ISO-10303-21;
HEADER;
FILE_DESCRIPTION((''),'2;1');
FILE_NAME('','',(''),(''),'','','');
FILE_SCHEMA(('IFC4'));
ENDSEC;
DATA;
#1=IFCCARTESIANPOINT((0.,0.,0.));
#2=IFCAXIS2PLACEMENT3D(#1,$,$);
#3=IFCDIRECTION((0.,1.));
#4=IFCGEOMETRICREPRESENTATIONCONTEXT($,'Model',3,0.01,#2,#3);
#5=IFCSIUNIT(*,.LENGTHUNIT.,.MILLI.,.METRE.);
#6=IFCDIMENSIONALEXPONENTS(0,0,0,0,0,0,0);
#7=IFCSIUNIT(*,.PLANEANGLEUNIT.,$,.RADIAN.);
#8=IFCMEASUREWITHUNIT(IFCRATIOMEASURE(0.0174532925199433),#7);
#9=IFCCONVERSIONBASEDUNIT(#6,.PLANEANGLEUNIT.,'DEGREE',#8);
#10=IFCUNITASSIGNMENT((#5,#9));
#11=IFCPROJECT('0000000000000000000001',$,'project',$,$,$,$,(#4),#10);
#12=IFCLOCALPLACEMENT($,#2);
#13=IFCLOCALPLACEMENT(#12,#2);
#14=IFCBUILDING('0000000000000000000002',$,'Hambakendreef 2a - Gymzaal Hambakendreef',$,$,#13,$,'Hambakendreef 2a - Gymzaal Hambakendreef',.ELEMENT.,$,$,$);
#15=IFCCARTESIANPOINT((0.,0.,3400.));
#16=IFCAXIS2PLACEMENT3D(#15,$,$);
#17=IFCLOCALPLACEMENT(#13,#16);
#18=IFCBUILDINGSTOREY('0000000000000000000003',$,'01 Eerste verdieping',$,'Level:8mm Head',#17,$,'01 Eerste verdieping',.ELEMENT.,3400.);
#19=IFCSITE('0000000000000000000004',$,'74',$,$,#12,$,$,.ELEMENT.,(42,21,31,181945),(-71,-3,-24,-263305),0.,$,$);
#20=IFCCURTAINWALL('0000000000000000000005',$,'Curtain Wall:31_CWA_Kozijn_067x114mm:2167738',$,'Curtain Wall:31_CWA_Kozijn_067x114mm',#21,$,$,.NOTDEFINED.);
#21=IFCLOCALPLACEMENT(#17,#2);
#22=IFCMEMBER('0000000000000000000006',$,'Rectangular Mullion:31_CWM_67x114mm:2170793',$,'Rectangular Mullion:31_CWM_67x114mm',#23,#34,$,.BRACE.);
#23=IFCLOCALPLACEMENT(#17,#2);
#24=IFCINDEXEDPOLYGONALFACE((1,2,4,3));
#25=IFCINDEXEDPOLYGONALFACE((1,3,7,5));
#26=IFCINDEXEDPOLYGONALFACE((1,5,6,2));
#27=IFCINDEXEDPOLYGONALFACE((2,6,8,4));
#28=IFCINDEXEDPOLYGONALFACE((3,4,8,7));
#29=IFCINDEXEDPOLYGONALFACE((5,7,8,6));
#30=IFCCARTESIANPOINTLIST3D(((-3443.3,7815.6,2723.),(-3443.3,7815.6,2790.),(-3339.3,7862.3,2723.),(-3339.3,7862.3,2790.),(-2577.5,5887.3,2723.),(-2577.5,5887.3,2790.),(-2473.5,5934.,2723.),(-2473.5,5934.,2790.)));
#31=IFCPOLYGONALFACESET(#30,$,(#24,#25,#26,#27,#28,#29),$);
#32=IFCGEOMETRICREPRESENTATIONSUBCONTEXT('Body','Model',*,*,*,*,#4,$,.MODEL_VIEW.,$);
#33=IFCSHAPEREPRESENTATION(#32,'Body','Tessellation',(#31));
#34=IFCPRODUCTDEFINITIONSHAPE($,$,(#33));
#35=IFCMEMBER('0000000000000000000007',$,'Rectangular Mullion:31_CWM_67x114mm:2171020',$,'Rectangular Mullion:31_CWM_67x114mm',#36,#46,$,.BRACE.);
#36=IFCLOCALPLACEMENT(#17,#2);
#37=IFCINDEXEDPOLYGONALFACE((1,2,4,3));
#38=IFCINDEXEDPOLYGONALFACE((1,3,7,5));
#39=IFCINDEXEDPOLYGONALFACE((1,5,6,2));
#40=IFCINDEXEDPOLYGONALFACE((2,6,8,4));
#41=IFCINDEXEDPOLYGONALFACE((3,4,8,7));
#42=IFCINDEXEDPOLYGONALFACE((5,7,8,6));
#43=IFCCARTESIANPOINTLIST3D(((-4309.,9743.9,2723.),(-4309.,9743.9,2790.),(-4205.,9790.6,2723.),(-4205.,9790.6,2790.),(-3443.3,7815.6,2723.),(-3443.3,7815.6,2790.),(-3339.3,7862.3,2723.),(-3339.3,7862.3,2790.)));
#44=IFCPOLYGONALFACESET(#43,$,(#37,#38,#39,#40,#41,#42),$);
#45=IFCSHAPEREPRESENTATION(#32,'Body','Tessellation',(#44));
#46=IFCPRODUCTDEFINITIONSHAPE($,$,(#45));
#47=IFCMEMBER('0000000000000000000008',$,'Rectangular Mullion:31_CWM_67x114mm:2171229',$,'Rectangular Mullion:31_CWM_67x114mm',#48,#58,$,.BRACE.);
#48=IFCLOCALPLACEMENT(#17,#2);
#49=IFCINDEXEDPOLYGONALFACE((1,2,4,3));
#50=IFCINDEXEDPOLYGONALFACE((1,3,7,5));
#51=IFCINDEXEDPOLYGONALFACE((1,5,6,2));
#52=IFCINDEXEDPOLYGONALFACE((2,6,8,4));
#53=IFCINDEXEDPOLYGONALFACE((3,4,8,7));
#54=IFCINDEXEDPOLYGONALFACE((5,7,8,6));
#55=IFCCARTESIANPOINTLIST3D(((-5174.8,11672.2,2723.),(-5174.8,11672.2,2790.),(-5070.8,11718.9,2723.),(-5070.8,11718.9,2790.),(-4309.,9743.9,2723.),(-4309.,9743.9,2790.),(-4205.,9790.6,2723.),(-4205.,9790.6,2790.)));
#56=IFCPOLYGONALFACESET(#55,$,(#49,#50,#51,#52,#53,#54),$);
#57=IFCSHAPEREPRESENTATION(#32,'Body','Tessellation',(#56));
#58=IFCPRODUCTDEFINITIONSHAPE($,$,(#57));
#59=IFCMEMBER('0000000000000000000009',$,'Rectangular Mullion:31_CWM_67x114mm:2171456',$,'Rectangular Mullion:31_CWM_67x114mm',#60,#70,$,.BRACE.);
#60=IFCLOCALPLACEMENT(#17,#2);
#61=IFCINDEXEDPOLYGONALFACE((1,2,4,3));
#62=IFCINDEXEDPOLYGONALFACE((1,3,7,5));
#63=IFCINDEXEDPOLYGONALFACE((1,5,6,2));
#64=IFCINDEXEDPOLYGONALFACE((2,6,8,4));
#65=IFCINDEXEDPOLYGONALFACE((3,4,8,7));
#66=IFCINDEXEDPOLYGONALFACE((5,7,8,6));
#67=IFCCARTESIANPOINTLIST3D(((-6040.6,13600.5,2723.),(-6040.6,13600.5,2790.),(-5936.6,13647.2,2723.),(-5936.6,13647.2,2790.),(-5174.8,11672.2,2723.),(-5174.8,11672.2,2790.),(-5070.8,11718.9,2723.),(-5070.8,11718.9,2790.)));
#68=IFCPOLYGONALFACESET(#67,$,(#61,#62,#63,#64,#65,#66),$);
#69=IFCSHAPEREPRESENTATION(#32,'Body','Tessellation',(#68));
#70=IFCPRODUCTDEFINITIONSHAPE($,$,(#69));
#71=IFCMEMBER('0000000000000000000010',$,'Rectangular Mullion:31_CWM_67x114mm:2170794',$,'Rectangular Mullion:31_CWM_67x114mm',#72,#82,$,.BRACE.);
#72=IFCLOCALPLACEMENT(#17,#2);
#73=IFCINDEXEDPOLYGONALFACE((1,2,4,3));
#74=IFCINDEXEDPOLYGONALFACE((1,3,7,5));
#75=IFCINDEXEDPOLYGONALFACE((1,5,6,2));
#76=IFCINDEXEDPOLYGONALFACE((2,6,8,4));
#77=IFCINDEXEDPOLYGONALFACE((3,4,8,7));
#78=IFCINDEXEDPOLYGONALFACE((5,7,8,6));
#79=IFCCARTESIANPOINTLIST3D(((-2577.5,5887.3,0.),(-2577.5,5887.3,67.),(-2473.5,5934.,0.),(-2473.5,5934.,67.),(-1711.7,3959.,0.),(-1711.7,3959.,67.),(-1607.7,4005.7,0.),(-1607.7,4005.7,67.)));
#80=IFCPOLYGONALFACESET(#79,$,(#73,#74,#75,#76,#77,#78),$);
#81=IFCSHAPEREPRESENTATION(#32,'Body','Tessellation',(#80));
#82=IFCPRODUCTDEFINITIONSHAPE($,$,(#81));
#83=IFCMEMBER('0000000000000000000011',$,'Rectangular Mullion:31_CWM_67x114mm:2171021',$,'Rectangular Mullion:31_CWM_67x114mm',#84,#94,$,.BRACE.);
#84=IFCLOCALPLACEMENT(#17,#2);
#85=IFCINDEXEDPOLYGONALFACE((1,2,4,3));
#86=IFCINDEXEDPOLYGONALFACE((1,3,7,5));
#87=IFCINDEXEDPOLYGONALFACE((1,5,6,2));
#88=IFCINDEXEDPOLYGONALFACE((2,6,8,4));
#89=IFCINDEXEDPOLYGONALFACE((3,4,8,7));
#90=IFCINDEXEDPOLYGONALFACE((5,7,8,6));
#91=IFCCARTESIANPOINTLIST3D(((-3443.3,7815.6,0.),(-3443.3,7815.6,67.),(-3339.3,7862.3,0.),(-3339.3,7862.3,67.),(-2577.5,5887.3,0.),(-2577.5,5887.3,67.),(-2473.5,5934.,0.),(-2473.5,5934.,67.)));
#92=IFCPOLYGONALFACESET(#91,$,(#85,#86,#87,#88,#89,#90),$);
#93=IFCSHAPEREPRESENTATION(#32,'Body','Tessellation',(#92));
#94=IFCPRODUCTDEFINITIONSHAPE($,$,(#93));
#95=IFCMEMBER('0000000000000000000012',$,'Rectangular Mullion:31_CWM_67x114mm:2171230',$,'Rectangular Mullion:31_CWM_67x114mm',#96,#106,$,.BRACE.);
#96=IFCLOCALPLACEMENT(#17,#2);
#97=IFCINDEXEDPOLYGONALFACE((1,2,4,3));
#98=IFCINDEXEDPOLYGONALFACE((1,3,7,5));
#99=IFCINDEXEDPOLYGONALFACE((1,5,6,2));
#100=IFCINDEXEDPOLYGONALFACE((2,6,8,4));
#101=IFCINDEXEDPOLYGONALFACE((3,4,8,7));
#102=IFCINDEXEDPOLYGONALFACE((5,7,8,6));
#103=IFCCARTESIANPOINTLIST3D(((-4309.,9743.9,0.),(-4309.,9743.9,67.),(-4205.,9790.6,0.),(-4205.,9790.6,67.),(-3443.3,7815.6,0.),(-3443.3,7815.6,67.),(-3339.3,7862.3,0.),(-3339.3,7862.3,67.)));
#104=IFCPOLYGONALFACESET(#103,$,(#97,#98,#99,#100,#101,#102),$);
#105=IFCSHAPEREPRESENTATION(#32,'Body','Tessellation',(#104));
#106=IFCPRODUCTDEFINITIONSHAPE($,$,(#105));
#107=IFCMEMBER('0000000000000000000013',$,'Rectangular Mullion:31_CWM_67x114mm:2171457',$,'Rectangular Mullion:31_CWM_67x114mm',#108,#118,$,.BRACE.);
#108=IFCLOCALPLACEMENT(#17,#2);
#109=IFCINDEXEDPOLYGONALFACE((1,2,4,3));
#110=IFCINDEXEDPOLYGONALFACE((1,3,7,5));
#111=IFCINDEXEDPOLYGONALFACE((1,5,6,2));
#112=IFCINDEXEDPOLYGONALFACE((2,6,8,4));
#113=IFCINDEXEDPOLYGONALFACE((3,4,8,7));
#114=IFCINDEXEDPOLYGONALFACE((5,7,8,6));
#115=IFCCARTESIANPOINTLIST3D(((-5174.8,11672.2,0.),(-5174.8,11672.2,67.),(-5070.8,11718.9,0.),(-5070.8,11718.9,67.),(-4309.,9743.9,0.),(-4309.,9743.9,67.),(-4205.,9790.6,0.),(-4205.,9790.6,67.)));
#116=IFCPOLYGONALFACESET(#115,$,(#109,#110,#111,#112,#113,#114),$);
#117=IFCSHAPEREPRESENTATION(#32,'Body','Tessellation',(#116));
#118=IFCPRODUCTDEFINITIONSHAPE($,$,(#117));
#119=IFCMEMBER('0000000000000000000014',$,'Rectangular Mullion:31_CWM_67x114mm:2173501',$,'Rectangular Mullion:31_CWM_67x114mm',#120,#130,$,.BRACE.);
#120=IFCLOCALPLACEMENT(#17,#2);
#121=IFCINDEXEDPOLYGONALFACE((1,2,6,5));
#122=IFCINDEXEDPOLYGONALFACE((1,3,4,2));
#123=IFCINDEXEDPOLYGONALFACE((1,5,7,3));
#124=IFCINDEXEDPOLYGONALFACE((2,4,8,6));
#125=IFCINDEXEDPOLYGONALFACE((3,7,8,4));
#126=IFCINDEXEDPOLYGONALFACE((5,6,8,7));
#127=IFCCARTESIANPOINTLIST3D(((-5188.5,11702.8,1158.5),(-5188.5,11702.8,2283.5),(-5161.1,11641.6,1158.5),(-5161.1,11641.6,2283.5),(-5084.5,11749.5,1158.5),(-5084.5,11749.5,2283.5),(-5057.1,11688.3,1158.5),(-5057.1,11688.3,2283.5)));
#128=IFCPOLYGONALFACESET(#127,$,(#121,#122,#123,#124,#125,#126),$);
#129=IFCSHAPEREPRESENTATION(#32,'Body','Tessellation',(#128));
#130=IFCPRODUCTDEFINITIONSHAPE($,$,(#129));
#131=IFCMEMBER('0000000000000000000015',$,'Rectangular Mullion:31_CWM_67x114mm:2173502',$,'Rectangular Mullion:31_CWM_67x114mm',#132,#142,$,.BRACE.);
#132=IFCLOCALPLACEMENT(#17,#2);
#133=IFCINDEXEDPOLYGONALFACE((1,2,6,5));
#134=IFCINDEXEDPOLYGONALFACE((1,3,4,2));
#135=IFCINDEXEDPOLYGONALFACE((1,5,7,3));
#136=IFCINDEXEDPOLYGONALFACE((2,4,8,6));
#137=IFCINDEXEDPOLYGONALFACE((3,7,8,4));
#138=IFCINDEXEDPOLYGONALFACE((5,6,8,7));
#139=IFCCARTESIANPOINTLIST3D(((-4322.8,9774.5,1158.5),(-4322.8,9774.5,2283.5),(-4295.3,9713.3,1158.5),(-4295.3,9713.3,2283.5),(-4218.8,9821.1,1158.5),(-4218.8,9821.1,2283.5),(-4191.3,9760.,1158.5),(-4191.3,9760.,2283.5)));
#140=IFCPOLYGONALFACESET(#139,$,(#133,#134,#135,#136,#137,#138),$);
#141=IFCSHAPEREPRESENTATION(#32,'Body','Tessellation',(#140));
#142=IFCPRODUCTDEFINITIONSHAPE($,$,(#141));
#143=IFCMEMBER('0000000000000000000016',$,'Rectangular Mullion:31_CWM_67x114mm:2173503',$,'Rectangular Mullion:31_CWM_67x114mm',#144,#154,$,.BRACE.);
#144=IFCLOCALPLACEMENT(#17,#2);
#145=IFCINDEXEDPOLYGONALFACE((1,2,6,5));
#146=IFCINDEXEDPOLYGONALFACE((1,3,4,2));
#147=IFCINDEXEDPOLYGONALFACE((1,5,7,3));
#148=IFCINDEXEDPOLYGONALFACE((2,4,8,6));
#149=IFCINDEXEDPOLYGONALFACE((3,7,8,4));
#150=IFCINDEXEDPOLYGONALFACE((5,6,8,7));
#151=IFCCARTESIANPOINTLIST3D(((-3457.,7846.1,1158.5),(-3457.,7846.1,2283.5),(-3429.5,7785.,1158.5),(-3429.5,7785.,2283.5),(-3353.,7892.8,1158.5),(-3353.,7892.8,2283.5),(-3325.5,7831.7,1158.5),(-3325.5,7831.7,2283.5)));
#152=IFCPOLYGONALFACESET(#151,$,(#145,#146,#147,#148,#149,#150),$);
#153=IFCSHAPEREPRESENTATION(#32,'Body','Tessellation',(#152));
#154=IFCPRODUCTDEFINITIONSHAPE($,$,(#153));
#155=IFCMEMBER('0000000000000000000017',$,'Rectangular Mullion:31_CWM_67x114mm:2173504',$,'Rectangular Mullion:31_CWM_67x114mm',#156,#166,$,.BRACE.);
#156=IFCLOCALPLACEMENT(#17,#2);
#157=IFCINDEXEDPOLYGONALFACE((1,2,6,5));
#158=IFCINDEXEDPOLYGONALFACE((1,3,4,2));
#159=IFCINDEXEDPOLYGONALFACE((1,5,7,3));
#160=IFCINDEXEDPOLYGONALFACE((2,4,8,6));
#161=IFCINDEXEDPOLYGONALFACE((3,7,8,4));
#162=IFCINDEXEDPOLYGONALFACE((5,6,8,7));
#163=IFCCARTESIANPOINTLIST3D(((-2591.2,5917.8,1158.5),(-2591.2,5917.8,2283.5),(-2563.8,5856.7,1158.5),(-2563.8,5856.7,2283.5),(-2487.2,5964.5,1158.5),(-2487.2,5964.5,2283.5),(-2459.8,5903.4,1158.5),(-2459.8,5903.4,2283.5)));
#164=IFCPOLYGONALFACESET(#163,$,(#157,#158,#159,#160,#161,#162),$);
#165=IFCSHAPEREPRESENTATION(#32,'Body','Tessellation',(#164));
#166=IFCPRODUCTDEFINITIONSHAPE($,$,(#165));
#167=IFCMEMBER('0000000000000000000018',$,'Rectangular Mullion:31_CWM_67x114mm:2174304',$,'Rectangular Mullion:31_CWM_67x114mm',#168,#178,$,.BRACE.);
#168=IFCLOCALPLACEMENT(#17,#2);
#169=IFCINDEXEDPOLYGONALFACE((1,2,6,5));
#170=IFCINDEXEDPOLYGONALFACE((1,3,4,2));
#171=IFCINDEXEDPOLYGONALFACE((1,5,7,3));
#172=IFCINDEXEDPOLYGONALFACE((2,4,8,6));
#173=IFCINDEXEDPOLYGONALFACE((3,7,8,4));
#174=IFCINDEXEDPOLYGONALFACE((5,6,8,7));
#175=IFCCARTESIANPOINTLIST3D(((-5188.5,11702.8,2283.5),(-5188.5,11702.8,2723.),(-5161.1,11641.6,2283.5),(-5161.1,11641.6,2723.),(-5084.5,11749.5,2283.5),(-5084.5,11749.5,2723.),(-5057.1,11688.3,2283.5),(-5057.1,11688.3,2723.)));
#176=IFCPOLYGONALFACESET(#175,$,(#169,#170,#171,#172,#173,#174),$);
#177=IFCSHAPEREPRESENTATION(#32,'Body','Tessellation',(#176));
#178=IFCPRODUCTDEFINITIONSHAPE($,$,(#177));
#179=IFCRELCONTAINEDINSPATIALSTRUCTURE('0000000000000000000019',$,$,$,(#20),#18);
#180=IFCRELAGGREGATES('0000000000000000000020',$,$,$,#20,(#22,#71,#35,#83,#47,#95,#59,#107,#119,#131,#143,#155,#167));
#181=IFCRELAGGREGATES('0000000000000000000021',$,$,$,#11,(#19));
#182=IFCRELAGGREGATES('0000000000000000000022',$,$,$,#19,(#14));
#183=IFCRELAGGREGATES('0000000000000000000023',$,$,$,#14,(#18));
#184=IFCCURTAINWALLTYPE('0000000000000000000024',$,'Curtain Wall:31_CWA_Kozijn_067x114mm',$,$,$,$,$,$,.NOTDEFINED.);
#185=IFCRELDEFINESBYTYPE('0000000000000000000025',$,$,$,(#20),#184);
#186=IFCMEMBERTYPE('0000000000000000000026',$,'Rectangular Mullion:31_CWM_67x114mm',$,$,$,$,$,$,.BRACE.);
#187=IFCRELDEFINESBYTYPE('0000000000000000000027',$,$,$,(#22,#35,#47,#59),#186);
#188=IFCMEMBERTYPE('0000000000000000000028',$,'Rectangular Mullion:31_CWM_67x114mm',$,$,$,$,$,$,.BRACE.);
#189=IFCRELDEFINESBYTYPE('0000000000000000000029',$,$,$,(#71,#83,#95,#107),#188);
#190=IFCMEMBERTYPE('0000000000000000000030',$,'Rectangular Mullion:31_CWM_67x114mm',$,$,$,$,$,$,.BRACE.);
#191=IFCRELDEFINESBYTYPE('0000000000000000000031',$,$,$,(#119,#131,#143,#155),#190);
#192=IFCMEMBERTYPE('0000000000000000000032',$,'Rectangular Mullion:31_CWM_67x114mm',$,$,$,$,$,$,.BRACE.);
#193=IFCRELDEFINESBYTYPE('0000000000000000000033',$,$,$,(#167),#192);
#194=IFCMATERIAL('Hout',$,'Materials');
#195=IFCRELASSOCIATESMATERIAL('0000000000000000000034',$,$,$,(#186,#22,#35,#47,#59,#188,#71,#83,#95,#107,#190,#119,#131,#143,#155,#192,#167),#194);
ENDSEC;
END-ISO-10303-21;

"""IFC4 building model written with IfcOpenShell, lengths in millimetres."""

from ifc_helpers import new_model, entity, si_unit, converted_unit, direction, frame, origin, place, context, subcontext, project, spatial, indexed_curve, outline, extrude, source, transform, mapped, material, type_object, type_shapes, element, aggregate, save


model = new_model("IFC4")

# Units and contexts
model_context = context("Model", 3, precision=0.01, world=origin(), true_north=direction((0.0, 1.0)))
body_context = subcontext(model_context, "Body", "Model", "MODEL_VIEW")
ifc_project = project(units=[si_unit("LENGTHUNIT", "METRE", prefix="MILLI"), converted_unit("PLANEANGLEUNIT", "DEGREE", entity("IfcRatioMeasure", 0.0174532925199433), si_unit("PLANEANGLEUNIT", "RADIAN"), dimensions=[0, 0, 0, 0, 0, 0, 0])], contexts=[model_context])

# Site, building, storey
site_placement = place(None, origin())
site = spatial("IfcSite", under=ifc_project, at=site_placement, Name="74", CompositionType="ELEMENT", RefLatitude=(42, 21, 31, 181945), RefLongitude=(-71, -3, -24, -263305), RefElevation=0.0)
building_placement = place(site_placement, origin())
building = spatial("IfcBuilding", under=site, at=building_placement, Name="Hambakendreef 2a - Gymzaal Hambakendreef", LongName="Hambakendreef 2a - Gymzaal Hambakendreef", CompositionType="ELEMENT")
storey_placement = place(building_placement, frame((0.0, 0.0, 3400.0)))
storey = spatial("IfcBuildingStorey", under=building, at=storey_placement, Name="01 Eerste verdieping", ObjectType="Level:8mm Head", LongName="01 Eerste verdieping", CompositionType="ELEMENT", Elevation=3400.0)

# Curtain wall, members
curtain_wall_type = type_object("IfcCurtainWallType", Name="Curtain Wall:31_CWA_Kozijn_067x114mm", PredefinedType="NOTDEFINED")
curtain_wall_placement = place(storey_placement, frame((0.0, 0.0, -3400.0)))
curtain_wall = element("IfcCurtainWall", 1, at=curtain_wall_placement, inside=storey, type_object=curtain_wall_type, Name="Curtain Wall:31_CWA_Kozijn_067x114mm:2167738", ObjectType="Curtain Wall:31_CWA_Kozijn_067x114mm", PredefinedType="NOTDEFINED")
ifc_material_1 = material(Name="Hout", Category="Materials")
member_type_1 = type_object("IfcMemberType", Name="Rectangular Mullion:31_CWM_67x114mm", PredefinedType="BRACE", material=ifc_material_1)
shared_shape_1 = source(origin(), body_context, "Body", "SweptSolid", [
    extrude(outline(indexed_curve([(-57.0, -33.5), (57.0, -33.5), (57.0, 33.5), (-57.0, 33.5), (-57.0, -33.5)], self_intersect=False)), frame((-33.5, 0.0, -2113.8), z_axis=(0.0, 0.0, 1.0), x_axis=(0.0, -1.0, 0.0)), (0.0, 0.0, 1.0), 2113.8),
])
type_shapes(member_type_1, [shared_shape_1])
member_1_placement = place(storey_placement, frame((-2525.5, 5910.6, 2790.0), z_axis=(0.40959, -0.91227, 0.0), x_axis=(0.0, 0.0, 1.0)))
member_1 = element("IfcMember", 2, at=member_1_placement, type_object=member_type_1, material=ifc_material_1, Name="Rectangular Mullion:31_CWM_67x114mm:2170793", ObjectType="Rectangular Mullion:31_CWM_67x114mm", PredefinedType="BRACE", context=body_context, shape_type="MappedRepresentation", body=[
    mapped(shared_shape_1, transform((0.0, 0.0, 0.0), scale=1.0)),
])
member_2_placement = place(storey_placement, frame((-3391.3, 7838.9, 2790.0), z_axis=(0.40959, -0.91227, 0.0), x_axis=(0.0, 0.0, 1.0)))
member_2 = element("IfcMember", 3, at=member_2_placement, type_object=member_type_1, material=ifc_material_1, Name="Rectangular Mullion:31_CWM_67x114mm:2171020", ObjectType="Rectangular Mullion:31_CWM_67x114mm", PredefinedType="BRACE", context=body_context, shape_type="MappedRepresentation", body=[
    mapped(shared_shape_1, transform((0.0, 0.0, 0.0), scale=1.0)),
])
member_3_placement = place(storey_placement, frame((-4257.0, 9767.2, 2790.0), z_axis=(0.40959, -0.91227, 0.0), x_axis=(0.0, 0.0, 1.0)))
member_3 = element("IfcMember", 4, at=member_3_placement, type_object=member_type_1, material=ifc_material_1, Name="Rectangular Mullion:31_CWM_67x114mm:2171229", ObjectType="Rectangular Mullion:31_CWM_67x114mm", PredefinedType="BRACE", context=body_context, shape_type="MappedRepresentation", body=[
    mapped(shared_shape_1, transform((0.0, 0.0, 0.0), scale=1.0)),
])
member_4_placement = place(storey_placement, frame((-5122.8, 11695.6, 2790.0), z_axis=(0.40959, -0.91227, 0.0), x_axis=(0.0, 0.0, 1.0)))
member_4 = element("IfcMember", 5, at=member_4_placement, type_object=member_type_1, material=ifc_material_1, Name="Rectangular Mullion:31_CWM_67x114mm:2171456", ObjectType="Rectangular Mullion:31_CWM_67x114mm", PredefinedType="BRACE", context=body_context, shape_type="MappedRepresentation", body=[
    mapped(shared_shape_1, transform((0.0, 0.0, 0.0), scale=1.0)),
])
member_type_2 = type_object("IfcMemberType", Name="Rectangular Mullion:31_CWM_67x114mm", PredefinedType="BRACE", material=ifc_material_1)
shared_shape_2 = source(origin(), body_context, "Body", "SweptSolid", [
    extrude(outline(indexed_curve([(-57.0, -33.5), (57.0, -33.5), (57.0, 33.5), (-57.0, 33.5), (-57.0, -33.5)], self_intersect=False)), frame((-33.5, 0.0, -2113.8), z_axis=(0.0, 0.0, 1.0), x_axis=(0.0, -1.0, 0.0)), (0.0, 0.0, 1.0), 2113.8),
])
type_shapes(member_type_2, [shared_shape_2])
member_5_placement = place(storey_placement, frame((-2525.5, 5910.6, 0.0), z_axis=(-0.40959, 0.91227, 0.0), x_axis=(0.0, 0.0, -1.0)))
member_5 = element("IfcMember", 6, at=member_5_placement, type_object=member_type_2, material=ifc_material_1, Name="Rectangular Mullion:31_CWM_67x114mm:2170794", ObjectType="Rectangular Mullion:31_CWM_67x114mm", PredefinedType="BRACE", context=body_context, shape_type="MappedRepresentation", body=[
    mapped(shared_shape_2, transform((0.0, 0.0, 0.0), scale=1.0)),
])
member_6_placement = place(storey_placement, frame((-3391.3, 7838.9, 0.0), z_axis=(-0.40959, 0.91227, 0.0), x_axis=(0.0, 0.0, -1.0)))
member_6 = element("IfcMember", 7, at=member_6_placement, type_object=member_type_2, material=ifc_material_1, Name="Rectangular Mullion:31_CWM_67x114mm:2171021", ObjectType="Rectangular Mullion:31_CWM_67x114mm", PredefinedType="BRACE", context=body_context, shape_type="MappedRepresentation", body=[
    mapped(shared_shape_2, transform((0.0, 0.0, 0.0), scale=1.0)),
])
member_7_placement = place(storey_placement, frame((-4257.0, 9767.2, 0.0), z_axis=(-0.40959, 0.91227, 0.0), x_axis=(0.0, 0.0, -1.0)))
member_7 = element("IfcMember", 8, at=member_7_placement, type_object=member_type_2, material=ifc_material_1, Name="Rectangular Mullion:31_CWM_67x114mm:2171230", ObjectType="Rectangular Mullion:31_CWM_67x114mm", PredefinedType="BRACE", context=body_context, shape_type="MappedRepresentation", body=[
    mapped(shared_shape_2, transform((0.0, 0.0, 0.0), scale=1.0)),
])
member_8_placement = place(storey_placement, frame((-5122.8, 11695.6, 0.0), z_axis=(-0.40959, 0.91227, 0.0), x_axis=(0.0, 0.0, -1.0)))
member_8 = element("IfcMember", 9, at=member_8_placement, type_object=member_type_2, material=ifc_material_1, Name="Rectangular Mullion:31_CWM_67x114mm:2171457", ObjectType="Rectangular Mullion:31_CWM_67x114mm", PredefinedType="BRACE", context=body_context, shape_type="MappedRepresentation", body=[
    mapped(shared_shape_2, transform((0.0, 0.0, 0.0), scale=1.0)),
])
member_type_3 = type_object("IfcMemberType", Name="Rectangular Mullion:31_CWM_67x114mm", PredefinedType="BRACE", material=ifc_material_1)
shared_shape_3 = source(origin(), body_context, "Body", "SweptSolid", [
    extrude(outline(indexed_curve([(-57.0, -33.5), (57.0, -33.5), (57.0, 33.5), (-57.0, 33.5), (-57.0, -33.5)], self_intersect=False)), frame((0.0, 0.0, -1125.0), z_axis=(0.0, 0.0, 1.0), x_axis=(0.0, -1.0, 0.0)), (0.0, 0.0, 1.0), 1125.0),
])
type_shapes(member_type_3, [shared_shape_3])
member_9_placement = place(storey_placement, frame((-5122.8, 11695.6, 1158.5), z_axis=(0.0, 0.0, -1.0), x_axis=(0.40959, -0.91227, 0.0)))
member_9 = element("IfcMember", 10, at=member_9_placement, type_object=member_type_3, material=ifc_material_1, Name="Rectangular Mullion:31_CWM_67x114mm:2173501", ObjectType="Rectangular Mullion:31_CWM_67x114mm", PredefinedType="BRACE", context=body_context, shape_type="MappedRepresentation", body=[
    mapped(shared_shape_3, transform((0.0, 0.0, 0.0), scale=1.0)),
])
member_10_placement = place(storey_placement, frame((-4257.0, 9767.2, 1158.5), z_axis=(0.0, 0.0, -1.0), x_axis=(0.40959, -0.91227, 0.0)))
member_10 = element("IfcMember", 11, at=member_10_placement, type_object=member_type_3, material=ifc_material_1, Name="Rectangular Mullion:31_CWM_67x114mm:2173502", ObjectType="Rectangular Mullion:31_CWM_67x114mm", PredefinedType="BRACE", context=body_context, shape_type="MappedRepresentation", body=[
    mapped(shared_shape_3, transform((0.0, 0.0, 0.0), scale=1.0)),
])
member_11_placement = place(storey_placement, frame((-3391.3, 7838.9, 1158.5), z_axis=(0.0, 0.0, -1.0), x_axis=(0.40959, -0.91227, 0.0)))
member_11 = element("IfcMember", 12, at=member_11_placement, type_object=member_type_3, material=ifc_material_1, Name="Rectangular Mullion:31_CWM_67x114mm:2173503", ObjectType="Rectangular Mullion:31_CWM_67x114mm", PredefinedType="BRACE", context=body_context, shape_type="MappedRepresentation", body=[
    mapped(shared_shape_3, transform((0.0, 0.0, 0.0), scale=1.0)),
])
member_12_placement = place(storey_placement, frame((-2525.5, 5910.6, 1158.5), z_axis=(0.0, 0.0, -1.0), x_axis=(0.40959, -0.91227, 0.0)))
member_12 = element("IfcMember", 13, at=member_12_placement, type_object=member_type_3, material=ifc_material_1, Name="Rectangular Mullion:31_CWM_67x114mm:2173504", ObjectType="Rectangular Mullion:31_CWM_67x114mm", PredefinedType="BRACE", context=body_context, shape_type="MappedRepresentation", body=[
    mapped(shared_shape_3, transform((0.0, 0.0, 0.0), scale=1.0)),
])
member_type_4 = type_object("IfcMemberType", Name="Rectangular Mullion:31_CWM_67x114mm", PredefinedType="BRACE", material=ifc_material_1)
shared_shape_4 = source(origin(), body_context, "Body", "SweptSolid", [
    extrude(outline(indexed_curve([(-57.0, -33.5), (57.0, -33.5), (57.0, 33.5), (-57.0, 33.5), (-57.0, -33.5)], self_intersect=False)), frame((0.0, 0.0, -439.5), z_axis=(0.0, 0.0, 1.0), x_axis=(0.0, -1.0, 0.0)), (0.0, 0.0, 1.0), 439.5),
])
type_shapes(member_type_4, [shared_shape_4])
member_13_placement = place(storey_placement, frame((-5122.8, 11695.6, 2283.5), z_axis=(0.0, 0.0, -1.0), x_axis=(0.40959, -0.91227, 0.0)))
member_13 = element("IfcMember", 14, at=member_13_placement, type_object=member_type_4, material=ifc_material_1, Name="Rectangular Mullion:31_CWM_67x114mm:2174304", ObjectType="Rectangular Mullion:31_CWM_67x114mm", PredefinedType="BRACE", context=body_context, shape_type="MappedRepresentation", body=[
    mapped(shared_shape_4, transform((0.0, 0.0, 0.0), scale=1.0)),
])
aggregate(curtain_wall, [member_1, member_5, member_2, member_6, member_3, member_7, member_4, member_8, member_9, member_10, member_11, member_12, member_13])

save(model, "model.ifc")
